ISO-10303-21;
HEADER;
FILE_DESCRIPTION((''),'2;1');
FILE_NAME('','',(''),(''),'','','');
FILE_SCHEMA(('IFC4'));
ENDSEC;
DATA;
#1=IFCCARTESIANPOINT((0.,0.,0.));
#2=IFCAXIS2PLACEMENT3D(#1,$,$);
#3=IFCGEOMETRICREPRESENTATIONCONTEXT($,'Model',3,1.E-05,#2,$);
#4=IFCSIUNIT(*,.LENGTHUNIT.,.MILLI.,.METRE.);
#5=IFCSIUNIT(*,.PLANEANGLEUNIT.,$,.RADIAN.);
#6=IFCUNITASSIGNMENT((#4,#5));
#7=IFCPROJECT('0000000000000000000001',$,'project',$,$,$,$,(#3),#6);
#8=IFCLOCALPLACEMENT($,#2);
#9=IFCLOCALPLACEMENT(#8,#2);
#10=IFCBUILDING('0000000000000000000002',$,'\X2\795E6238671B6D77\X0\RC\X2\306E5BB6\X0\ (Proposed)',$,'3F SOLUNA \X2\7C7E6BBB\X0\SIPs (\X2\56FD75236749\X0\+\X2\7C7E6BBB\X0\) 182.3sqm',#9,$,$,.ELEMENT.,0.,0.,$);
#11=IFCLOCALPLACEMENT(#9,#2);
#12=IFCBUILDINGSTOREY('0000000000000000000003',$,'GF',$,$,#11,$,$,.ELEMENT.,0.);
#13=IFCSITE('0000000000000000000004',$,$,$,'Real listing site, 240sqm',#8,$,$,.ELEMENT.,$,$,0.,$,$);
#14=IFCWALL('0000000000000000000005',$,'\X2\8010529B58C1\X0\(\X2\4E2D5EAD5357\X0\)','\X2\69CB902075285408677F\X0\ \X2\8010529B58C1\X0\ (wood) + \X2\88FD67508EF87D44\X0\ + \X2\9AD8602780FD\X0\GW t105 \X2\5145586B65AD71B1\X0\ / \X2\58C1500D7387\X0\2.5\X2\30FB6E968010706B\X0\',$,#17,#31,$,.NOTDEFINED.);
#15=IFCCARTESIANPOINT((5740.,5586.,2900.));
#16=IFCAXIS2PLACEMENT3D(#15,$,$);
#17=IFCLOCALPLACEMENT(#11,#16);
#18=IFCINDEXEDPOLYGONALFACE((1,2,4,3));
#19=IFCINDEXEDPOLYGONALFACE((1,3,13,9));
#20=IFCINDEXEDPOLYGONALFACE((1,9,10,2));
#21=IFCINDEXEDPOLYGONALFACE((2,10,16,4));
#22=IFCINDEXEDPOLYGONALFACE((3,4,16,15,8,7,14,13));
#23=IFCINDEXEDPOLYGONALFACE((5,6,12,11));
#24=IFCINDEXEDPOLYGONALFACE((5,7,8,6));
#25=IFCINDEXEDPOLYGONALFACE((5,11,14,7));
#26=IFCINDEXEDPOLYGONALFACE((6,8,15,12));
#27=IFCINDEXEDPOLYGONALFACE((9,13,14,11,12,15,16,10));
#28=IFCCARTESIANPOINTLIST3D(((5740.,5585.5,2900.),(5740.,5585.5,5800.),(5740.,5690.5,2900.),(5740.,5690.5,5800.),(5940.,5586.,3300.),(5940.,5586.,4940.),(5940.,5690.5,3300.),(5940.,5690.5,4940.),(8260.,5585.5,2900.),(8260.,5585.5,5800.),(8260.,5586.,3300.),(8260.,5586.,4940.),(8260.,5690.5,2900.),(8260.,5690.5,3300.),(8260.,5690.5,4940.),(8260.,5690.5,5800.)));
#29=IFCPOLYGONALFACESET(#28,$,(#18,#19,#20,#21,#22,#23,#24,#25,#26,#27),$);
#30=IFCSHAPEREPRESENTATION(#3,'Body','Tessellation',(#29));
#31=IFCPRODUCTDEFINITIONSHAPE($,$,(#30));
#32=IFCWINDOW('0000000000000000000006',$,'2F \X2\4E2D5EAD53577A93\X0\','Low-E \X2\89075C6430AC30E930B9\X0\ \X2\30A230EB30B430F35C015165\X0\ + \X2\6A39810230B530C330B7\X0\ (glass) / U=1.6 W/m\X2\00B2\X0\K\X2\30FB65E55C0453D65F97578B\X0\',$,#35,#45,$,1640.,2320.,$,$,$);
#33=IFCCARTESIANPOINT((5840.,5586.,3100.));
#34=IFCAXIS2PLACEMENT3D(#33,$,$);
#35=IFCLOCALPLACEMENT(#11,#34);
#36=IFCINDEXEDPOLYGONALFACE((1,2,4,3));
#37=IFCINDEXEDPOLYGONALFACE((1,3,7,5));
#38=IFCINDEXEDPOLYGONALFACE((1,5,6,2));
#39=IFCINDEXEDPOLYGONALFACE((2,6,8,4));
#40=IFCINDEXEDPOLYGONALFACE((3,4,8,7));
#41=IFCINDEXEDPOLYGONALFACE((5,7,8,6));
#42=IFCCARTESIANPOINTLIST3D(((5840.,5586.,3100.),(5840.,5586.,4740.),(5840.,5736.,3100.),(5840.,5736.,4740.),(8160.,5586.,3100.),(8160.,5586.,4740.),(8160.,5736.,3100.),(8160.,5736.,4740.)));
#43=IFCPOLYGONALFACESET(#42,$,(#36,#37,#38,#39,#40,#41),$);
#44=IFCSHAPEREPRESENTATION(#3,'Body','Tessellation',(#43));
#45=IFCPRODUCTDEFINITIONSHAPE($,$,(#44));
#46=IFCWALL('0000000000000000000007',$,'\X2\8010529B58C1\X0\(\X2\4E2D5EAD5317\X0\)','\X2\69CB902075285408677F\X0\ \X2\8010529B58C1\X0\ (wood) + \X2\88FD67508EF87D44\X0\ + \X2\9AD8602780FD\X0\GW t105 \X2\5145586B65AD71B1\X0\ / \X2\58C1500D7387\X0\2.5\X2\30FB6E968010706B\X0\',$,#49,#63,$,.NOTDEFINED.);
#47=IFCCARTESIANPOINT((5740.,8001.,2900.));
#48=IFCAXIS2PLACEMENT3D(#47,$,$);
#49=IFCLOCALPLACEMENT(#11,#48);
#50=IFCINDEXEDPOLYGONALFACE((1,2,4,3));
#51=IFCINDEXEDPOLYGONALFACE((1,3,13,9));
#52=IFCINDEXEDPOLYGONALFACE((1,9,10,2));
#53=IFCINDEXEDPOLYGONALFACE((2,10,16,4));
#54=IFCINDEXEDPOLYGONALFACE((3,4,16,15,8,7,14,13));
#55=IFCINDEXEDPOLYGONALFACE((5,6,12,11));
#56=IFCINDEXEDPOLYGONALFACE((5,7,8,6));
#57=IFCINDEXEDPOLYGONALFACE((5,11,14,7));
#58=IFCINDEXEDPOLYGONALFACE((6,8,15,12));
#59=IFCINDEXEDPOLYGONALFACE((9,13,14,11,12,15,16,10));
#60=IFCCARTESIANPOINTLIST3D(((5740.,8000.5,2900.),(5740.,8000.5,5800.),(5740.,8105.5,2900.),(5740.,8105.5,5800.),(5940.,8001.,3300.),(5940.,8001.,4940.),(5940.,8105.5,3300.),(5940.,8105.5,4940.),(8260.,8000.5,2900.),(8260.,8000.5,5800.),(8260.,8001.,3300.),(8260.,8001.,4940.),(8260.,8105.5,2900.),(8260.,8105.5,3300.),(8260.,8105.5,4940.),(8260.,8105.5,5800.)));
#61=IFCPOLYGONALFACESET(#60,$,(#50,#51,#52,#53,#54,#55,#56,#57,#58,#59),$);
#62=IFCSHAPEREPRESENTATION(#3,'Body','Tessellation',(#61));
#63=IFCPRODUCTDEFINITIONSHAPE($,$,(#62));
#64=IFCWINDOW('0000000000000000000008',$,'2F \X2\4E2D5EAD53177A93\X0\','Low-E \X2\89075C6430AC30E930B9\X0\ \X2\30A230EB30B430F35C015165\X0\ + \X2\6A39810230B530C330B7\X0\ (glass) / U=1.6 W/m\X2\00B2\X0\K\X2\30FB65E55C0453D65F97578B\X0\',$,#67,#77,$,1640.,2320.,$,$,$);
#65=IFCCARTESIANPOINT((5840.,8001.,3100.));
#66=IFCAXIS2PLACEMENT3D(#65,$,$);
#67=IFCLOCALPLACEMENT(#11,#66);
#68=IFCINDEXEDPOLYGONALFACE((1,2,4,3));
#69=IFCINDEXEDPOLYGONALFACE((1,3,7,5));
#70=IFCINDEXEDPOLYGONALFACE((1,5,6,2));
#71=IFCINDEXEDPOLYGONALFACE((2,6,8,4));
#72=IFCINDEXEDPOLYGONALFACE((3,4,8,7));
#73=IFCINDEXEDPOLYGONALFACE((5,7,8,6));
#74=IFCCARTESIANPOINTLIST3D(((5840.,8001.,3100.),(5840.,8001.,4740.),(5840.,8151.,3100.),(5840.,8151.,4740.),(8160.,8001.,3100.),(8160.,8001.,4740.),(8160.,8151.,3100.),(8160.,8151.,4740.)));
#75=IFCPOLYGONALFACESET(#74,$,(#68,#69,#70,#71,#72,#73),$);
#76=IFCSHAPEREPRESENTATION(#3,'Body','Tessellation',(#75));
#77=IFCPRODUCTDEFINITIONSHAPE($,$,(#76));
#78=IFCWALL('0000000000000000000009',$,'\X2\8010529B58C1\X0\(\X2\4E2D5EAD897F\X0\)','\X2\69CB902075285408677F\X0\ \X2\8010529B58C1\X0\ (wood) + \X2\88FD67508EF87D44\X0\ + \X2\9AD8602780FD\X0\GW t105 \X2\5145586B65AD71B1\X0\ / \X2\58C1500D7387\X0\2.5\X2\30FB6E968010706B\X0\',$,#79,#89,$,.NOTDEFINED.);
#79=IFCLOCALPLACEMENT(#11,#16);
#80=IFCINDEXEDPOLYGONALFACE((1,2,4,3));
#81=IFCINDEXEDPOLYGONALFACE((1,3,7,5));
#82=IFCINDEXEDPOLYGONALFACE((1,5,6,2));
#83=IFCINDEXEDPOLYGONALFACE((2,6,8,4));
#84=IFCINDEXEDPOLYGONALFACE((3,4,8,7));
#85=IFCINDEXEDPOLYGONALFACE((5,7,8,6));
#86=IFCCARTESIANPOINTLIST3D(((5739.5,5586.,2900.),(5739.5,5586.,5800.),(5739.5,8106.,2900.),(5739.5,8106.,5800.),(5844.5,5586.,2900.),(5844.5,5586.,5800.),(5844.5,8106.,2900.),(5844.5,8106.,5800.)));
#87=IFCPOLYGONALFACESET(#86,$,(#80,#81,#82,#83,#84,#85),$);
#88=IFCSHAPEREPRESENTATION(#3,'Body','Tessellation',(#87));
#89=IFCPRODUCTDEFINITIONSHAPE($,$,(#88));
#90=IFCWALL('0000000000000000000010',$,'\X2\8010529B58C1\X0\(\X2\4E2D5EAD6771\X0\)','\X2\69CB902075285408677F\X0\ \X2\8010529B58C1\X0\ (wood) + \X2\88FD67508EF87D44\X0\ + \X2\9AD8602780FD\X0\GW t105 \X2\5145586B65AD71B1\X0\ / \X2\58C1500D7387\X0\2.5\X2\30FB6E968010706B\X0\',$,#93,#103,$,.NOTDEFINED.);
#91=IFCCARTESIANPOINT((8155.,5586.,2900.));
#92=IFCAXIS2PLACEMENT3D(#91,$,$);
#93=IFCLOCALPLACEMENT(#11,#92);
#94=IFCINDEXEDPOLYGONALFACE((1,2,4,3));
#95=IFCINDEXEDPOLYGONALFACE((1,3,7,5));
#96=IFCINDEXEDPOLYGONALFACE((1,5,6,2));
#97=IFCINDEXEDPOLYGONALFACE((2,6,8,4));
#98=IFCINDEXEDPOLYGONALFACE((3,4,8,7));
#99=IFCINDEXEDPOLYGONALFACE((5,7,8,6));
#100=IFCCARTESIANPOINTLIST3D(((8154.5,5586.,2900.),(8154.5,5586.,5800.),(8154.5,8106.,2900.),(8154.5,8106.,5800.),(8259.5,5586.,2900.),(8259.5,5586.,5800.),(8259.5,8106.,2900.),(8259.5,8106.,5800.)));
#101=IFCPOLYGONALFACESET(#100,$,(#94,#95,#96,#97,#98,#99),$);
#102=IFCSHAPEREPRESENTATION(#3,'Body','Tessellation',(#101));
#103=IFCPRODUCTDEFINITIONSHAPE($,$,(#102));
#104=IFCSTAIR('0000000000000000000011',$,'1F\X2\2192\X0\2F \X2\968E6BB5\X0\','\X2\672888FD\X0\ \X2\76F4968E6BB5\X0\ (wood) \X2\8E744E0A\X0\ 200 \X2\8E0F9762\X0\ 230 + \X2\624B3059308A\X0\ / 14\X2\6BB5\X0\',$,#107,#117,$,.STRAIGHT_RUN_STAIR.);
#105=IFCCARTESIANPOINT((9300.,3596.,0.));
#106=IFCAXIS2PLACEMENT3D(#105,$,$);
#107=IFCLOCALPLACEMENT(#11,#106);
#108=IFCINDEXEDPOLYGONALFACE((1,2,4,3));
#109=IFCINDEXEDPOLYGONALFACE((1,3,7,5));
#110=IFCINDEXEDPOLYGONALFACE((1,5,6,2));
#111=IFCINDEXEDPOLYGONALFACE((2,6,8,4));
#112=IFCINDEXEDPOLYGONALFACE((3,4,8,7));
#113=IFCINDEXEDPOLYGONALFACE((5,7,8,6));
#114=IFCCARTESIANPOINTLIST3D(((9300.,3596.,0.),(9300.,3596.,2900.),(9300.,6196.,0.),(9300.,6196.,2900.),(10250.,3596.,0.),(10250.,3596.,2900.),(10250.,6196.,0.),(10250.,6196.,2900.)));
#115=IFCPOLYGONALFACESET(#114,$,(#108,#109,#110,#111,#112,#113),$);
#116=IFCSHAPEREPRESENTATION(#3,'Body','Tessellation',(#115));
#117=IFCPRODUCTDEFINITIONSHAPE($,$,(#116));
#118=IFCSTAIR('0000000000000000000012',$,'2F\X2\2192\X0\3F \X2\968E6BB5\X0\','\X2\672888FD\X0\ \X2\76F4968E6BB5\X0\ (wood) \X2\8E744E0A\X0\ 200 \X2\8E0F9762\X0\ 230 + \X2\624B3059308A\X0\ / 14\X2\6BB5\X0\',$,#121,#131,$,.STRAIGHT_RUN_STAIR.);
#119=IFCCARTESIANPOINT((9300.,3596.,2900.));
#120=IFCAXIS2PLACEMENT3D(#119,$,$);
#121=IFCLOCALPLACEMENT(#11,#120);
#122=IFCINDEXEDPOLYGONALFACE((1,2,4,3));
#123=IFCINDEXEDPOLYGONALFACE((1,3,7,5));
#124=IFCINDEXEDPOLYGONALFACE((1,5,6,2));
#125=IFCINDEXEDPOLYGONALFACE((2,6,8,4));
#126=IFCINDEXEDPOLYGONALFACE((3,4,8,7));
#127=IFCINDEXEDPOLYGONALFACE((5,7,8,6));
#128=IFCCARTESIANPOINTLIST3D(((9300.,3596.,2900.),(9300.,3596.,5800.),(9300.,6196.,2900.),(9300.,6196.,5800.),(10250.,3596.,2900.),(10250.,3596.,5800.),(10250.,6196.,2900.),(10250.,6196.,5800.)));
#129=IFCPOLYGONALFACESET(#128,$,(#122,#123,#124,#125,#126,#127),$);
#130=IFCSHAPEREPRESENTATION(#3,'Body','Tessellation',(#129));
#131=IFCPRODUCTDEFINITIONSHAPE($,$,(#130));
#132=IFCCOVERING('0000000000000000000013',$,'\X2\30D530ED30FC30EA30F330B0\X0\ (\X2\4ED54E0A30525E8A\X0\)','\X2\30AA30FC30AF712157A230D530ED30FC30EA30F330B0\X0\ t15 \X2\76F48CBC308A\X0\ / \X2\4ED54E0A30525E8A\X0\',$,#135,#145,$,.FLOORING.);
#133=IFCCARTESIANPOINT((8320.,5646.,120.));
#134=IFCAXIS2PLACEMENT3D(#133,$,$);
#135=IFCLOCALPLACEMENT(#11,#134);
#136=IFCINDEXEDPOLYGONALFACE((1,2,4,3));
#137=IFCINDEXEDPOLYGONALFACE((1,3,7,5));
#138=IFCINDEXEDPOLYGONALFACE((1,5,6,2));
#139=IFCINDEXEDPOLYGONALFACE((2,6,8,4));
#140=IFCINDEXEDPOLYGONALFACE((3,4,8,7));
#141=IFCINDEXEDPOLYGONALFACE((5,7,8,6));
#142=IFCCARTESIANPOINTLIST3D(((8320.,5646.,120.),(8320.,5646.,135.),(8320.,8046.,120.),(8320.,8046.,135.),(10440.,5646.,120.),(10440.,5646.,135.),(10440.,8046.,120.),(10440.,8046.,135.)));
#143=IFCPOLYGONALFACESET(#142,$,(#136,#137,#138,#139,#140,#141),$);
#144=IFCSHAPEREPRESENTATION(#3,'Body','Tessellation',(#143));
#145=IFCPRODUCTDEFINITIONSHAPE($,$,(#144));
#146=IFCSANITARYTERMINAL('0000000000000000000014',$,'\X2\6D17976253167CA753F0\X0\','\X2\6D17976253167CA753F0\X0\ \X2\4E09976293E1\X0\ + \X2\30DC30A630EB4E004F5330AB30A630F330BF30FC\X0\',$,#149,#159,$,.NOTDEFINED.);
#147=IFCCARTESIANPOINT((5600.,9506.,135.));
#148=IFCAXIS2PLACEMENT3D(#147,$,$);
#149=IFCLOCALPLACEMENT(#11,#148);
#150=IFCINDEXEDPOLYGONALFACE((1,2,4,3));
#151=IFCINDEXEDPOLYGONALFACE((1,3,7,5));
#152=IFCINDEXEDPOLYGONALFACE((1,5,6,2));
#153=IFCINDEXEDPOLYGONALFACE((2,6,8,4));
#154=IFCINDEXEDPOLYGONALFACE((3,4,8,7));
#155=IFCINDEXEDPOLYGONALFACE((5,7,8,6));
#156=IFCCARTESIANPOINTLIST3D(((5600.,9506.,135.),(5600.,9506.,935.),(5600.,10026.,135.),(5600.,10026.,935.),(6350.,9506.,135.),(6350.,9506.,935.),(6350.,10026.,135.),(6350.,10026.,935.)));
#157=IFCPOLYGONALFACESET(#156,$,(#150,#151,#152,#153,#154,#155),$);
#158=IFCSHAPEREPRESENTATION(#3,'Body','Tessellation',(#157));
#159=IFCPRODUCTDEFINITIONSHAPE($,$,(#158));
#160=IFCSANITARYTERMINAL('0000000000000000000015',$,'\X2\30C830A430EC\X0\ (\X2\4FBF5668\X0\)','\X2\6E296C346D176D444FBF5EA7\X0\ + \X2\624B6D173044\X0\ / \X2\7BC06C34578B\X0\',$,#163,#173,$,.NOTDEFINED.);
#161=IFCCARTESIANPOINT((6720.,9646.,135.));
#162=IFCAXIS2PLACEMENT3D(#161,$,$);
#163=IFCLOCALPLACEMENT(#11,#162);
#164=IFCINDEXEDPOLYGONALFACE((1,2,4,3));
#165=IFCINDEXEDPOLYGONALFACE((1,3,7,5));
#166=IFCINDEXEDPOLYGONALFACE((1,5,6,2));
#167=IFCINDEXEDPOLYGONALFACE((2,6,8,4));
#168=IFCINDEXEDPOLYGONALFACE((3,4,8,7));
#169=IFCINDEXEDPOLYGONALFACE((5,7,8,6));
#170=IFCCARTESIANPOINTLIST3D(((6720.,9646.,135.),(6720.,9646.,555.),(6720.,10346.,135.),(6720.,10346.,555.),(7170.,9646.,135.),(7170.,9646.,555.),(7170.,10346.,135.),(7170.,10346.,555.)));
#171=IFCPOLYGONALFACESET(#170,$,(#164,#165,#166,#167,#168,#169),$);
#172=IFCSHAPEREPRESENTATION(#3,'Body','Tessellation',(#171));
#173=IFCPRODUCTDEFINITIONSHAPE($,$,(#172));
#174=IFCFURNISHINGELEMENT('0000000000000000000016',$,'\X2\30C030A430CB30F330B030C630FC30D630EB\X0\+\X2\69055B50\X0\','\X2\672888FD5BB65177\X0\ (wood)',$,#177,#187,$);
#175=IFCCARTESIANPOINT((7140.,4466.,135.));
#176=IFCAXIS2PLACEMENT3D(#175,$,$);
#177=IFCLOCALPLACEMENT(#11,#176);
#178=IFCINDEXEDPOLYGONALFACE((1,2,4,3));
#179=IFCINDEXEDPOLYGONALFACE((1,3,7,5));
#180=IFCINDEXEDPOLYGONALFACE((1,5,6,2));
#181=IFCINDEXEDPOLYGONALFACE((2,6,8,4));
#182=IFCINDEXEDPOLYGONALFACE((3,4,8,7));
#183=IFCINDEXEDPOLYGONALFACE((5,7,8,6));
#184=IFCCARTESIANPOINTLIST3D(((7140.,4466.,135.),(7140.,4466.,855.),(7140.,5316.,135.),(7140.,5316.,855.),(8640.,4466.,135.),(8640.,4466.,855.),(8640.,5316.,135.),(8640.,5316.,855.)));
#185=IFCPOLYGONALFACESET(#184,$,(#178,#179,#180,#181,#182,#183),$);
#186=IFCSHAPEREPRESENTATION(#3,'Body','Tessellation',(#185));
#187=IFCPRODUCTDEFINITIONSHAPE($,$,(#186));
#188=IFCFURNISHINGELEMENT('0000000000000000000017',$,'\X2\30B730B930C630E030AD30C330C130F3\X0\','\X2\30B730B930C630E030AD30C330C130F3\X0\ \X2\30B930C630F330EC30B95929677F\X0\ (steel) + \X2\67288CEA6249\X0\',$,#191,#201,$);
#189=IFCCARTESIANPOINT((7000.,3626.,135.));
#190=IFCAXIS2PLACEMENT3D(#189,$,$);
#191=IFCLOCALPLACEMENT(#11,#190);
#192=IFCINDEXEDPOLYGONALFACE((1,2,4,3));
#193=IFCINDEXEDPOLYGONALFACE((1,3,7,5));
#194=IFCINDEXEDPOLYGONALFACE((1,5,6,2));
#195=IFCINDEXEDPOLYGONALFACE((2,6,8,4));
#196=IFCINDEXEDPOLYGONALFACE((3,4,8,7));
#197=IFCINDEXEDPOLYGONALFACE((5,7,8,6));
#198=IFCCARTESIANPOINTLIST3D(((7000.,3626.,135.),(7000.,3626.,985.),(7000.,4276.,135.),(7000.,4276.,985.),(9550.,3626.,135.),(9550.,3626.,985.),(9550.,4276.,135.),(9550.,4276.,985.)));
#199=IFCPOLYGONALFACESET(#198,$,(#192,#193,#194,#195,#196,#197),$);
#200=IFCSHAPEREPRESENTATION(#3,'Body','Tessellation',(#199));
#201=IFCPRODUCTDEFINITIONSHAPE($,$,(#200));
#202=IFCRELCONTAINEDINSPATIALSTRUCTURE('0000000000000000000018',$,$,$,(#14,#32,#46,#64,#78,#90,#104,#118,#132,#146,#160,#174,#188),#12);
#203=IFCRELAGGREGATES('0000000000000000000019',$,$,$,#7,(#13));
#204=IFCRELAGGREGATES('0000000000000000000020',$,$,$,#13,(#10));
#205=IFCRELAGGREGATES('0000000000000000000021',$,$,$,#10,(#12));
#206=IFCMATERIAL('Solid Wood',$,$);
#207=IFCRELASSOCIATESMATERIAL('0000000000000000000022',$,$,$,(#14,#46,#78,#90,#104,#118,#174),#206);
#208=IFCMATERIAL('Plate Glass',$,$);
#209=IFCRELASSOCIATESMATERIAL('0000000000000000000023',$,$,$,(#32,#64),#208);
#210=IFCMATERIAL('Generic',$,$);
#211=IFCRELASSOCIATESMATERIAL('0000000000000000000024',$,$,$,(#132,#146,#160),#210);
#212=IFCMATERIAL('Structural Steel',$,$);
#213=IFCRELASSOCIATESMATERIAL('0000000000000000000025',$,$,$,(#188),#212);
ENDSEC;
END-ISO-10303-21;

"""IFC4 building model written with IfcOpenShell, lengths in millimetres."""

from ifc_helpers import new_model, si_unit, frame, frame_2d, origin, place, context, project, spatial, rectangle, extrude, material, element, fill, save


model = new_model("IFC4")

# Units and contexts
model_context = context("Model", 3, precision=1e-05, world=origin())
ifc_project = project(units=[si_unit("LENGTHUNIT", "METRE", prefix="MILLI"), si_unit("PLANEANGLEUNIT", "RADIAN")], contexts=[model_context])

# Site, building, storey
site_placement = place(None, origin())
site = spatial("IfcSite", under=ifc_project, at=site_placement, ObjectType="Real listing site, 240sqm", CompositionType="ELEMENT", RefElevation=0.0)
building_placement = place(site_placement, origin())
building = spatial("IfcBuilding", under=site, at=building_placement, Name="神戸望海RCの家 (Proposed)", ObjectType="3F SOLUNA 籾殻SIPs (国産杉+籾殻) 182.3sqm", CompositionType="ELEMENT", ElevationOfRefHeight=0.0, ElevationOfTerrain=0.0)
storey_placement = place(building_placement, origin())
storey = spatial("IfcBuildingStorey", under=building, at=storey_placement, Name="GF", CompositionType="ELEMENT", Elevation=0.0)

# Shared definitions
ifc_material_1 = material(Name="Solid Wood")

# Shared definitions
ifc_material_2 = material(Name="Plate Glass")

# Walls, openings, windows
wall_1_placement = place(storey_placement, frame((5740.0, 5586.0, 2900.0)))
wall_1 = element("IfcWall", 1, at=wall_1_placement, inside=storey, material=ifc_material_1, Name="耐力壁(中庭南)", Description="構造用合板 耐力壁 (wood) + 製材軸組 + 高性能GW t105 充填断熱 / 壁倍率2.5・準耐火", PredefinedType="NOTDEFINED", context=model_context, shape_type="SweptSolid", body=[
    extrude(rectangle(XDim=2520.0, YDim=105.0, at=frame_2d((1260.0, 52.0))), frame((5740.0, 5586.0, 2900.0)), (0.0, 0.0, 1.0), 2900.0),
])
opening_1_placement = place(storey_placement, frame((5840.0, 5586.0, 3100.0)))
opening_1 = element("IfcOpeningElement", 2, at=opening_1_placement, cuts=wall_1, PredefinedType="NOTDEFINED", context=model_context, shape_type="SweptSolid", body=[
    extrude(rectangle(XDim=2320.0, YDim=150.0, at=frame_2d((1160.0, 75.0))), frame((5840.0, 5586.0, 3100.0)), (0.0, 0.0, 1.0), 1640.0),
])
window_1_placement = place(storey_placement, frame((5840.0, 5586.0, 3100.0)))
window_1 = element("IfcWindow", 3, at=window_1_placement, inside=storey, material=ifc_material_2, Name="2F 中庭南窓", Description="Low-E 複層ガラス アルゴン封入 + 樹脂サッシ (glass) / U=1.6 W/m²K・日射取得型", OverallHeight=1640.0, OverallWidth=2320.0, context=model_context, shape_type="SweptSolid", body=[
    extrude(rectangle(XDim=2320.0, YDim=150.0, at=frame_2d((1160.0, 75.0))), frame((5840.0, 5586.0, 3100.0)), (0.0, 0.0, 1.0), 1640.0),
])
fill(opening_1, window_1)
wall_2_placement = place(storey_placement, frame((5740.0, 8001.0, 2900.0)))
wall_2 = element("IfcWall", 4, at=wall_2_placement, inside=storey, material=ifc_material_1, Name="耐力壁(中庭北)", Description="構造用合板 耐力壁 (wood) + 製材軸組 + 高性能GW t105 充填断熱 / 壁倍率2.5・準耐火", PredefinedType="NOTDEFINED", context=model_context, shape_type="SweptSolid", body=[
    extrude(rectangle(XDim=2520.0, YDim=105.0, at=frame_2d((1260.0, 52.0))), frame((5740.0, 8001.0, 2900.0)), (0.0, 0.0, 1.0), 2900.0),
])
opening_2_placement = place(storey_placement, frame((5840.0, 8001.0, 3100.0)))
opening_2 = element("IfcOpeningElement", 5, at=opening_2_placement, cuts=wall_2, PredefinedType="NOTDEFINED", context=model_context, shape_type="SweptSolid", body=[
    extrude(rectangle(XDim=2320.0, YDim=150.0, at=frame_2d((1160.0, 75.0))), frame((5840.0, 8001.0, 3100.0)), (0.0, 0.0, 1.0), 1640.0),
])
window_2_placement = place(storey_placement, frame((5840.0, 8001.0, 3100.0)))
window_2 = element("IfcWindow", 6, at=window_2_placement, inside=storey, material=ifc_material_2, Name="2F 中庭北窓", Description="Low-E 複層ガラス アルゴン封入 + 樹脂サッシ (glass) / U=1.6 W/m²K・日射取得型", OverallHeight=1640.0, OverallWidth=2320.0, context=model_context, shape_type="SweptSolid", body=[
    extrude(rectangle(XDim=2320.0, YDim=150.0, at=frame_2d((1160.0, 75.0))), frame((5840.0, 8001.0, 3100.0)), (0.0, 0.0, 1.0), 1640.0),
])
fill(opening_2, window_2)

# Walls
wall_3_placement = place(storey_placement, frame((5740.0, 5586.0, 2900.0)))
element("IfcWall", 7, at=wall_3_placement, inside=storey, material=ifc_material_1, Name="耐力壁(中庭西)", Description="構造用合板 耐力壁 (wood) + 製材軸組 + 高性能GW t105 充填断熱 / 壁倍率2.5・準耐火", PredefinedType="NOTDEFINED", context=model_context, shape_type="SweptSolid", body=[
    extrude(rectangle(XDim=105.0, YDim=2520.0, at=frame_2d((52.0, 1260.0))), frame((5740.0, 5586.0, 2900.0)), (0.0, 0.0, 1.0), 2900.0),
])
wall_4_placement = place(storey_placement, frame((8155.0, 5586.0, 2900.0)))
element("IfcWall", 8, at=wall_4_placement, inside=storey, material=ifc_material_1, Name="耐力壁(中庭東)", Description="構造用合板 耐力壁 (wood) + 製材軸組 + 高性能GW t105 充填断熱 / 壁倍率2.5・準耐火", PredefinedType="NOTDEFINED", context=model_context, shape_type="SweptSolid", body=[
    extrude(rectangle(XDim=105.0, YDim=2520.0, at=frame_2d((52.0, 1260.0))), frame((8155.0, 5586.0, 2900.0)), (0.0, 0.0, 1.0), 2900.0),
])

# Stairs
stair_1_placement = place(storey_placement, frame((9300.0, 3596.0, 0.0)))
element("IfcStair", 9, at=stair_1_placement, inside=storey, material=ifc_material_1, Name="1F→2F 階段", Description="木製 直階段 (wood) 蹴上 200 踏面 230 + 手すり / 14段", PredefinedType="STRAIGHT_RUN_STAIR", context=model_context, shape_type="SweptSolid", body=[
    extrude(rectangle(XDim=950.0, YDim=2600.0, at=frame_2d((475.0, 1300.0))), frame((9300.0, 3596.0, 0.0)), (0.0, 0.0, 1.0), 2900.0),
])
stair_2_placement = place(storey_placement, frame((9300.0, 3596.0, 2900.0)))
element("IfcStair", 10, at=stair_2_placement, inside=storey, material=ifc_material_1, Name="2F→3F 階段", Description="木製 直階段 (wood) 蹴上 200 踏面 230 + 手すり / 14段", PredefinedType="STRAIGHT_RUN_STAIR", context=model_context, shape_type="SweptSolid", body=[
    extrude(rectangle(XDim=950.0, YDim=2600.0, at=frame_2d((475.0, 1300.0))), frame((9300.0, 3596.0, 2900.0)), (0.0, 0.0, 1.0), 2900.0),
])

# Covering
ifc_material_3 = material(Name="Generic")
covering_placement = place(storey_placement, frame((8320.0, 5646.0, 120.0)))
element("IfcCovering", 11, at=covering_placement, inside=storey, material=ifc_material_3, Name="フローリング (仕上げ床)", Description="オーク無垢フローリング t15 直貼り / 仕上げ床", PredefinedType="FLOORING", context=model_context, shape_type="SweptSolid", body=[
    extrude(rectangle(XDim=2120.0, YDim=2400.0, at=frame_2d((1060.0, 1200.0))), frame((8320.0, 5646.0, 120.0)), (0.0, 0.0, 1.0), 15.0),
])

# Sanitary terminals
sanitary_terminal_1_placement = place(storey_placement, frame((5600.0, 9506.0, 135.0)))
element("IfcSanitaryTerminal", 12, at=sanitary_terminal_1_placement, inside=storey, material=ifc_material_3, Name="洗面化粧台", Description="洗面化粧台 三面鏡 + ボウル一体カウンター", PredefinedType="NOTDEFINED", context=model_context, shape_type="SweptSolid", body=[
    extrude(rectangle(XDim=750.0, YDim=520.0, at=frame_2d((375.0, 260.0))), frame((5600.0, 9506.0, 135.0)), (0.0, 0.0, 1.0), 800.0),
])
sanitary_terminal_2_placement = place(storey_placement, frame((6720.0, 9646.0, 135.0)))
element("IfcSanitaryTerminal", 13, at=sanitary_terminal_2_placement, inside=storey, material=ifc_material_3, Name="トイレ (便器)", Description="温水洗浄便座 + 手洗い / 節水型", PredefinedType="NOTDEFINED", context=model_context, shape_type="SweptSolid", body=[
    extrude(rectangle(XDim=450.0, YDim=700.0, at=frame_2d((225.0, 350.0))), frame((6720.0, 9646.0, 135.0)), (0.0, 0.0, 1.0), 420.0),
])

# Furnishing elements
furnishing_1_placement = place(storey_placement, frame((7140.0, 4466.0, 135.0)))
element("IfcFurnishingElement", 14, at=furnishing_1_placement, inside=storey, material=ifc_material_1, Name="ダイニングテーブル+椅子", Description="木製家具 (wood)", context=model_context, shape_type="SweptSolid", body=[
    extrude(rectangle(XDim=1500.0, YDim=850.0, at=frame_2d((750.0, 425.0))), frame((7140.0, 4466.0, 135.0)), (0.0, 0.0, 1.0), 720.0),
])
ifc_material_4 = material(Name="Structural Steel")
furnishing_2_placement = place(storey_placement, frame((7000.0, 3626.0, 135.0)))
element("IfcFurnishingElement", 15, at=furnishing_2_placement, inside=storey, material=ifc_material_4, Name="システムキッチン", Description="システムキッチン ステンレス天板 (steel) + 木質扉", context=model_context, shape_type="SweptSolid", body=[
    extrude(rectangle(XDim=2550.0, YDim=650.0, at=frame_2d((1275.0, 325.0))), frame((7000.0, 3626.0, 135.0)), (0.0, 0.0, 1.0), 850.0),
])

save(model, "model.ifc")
